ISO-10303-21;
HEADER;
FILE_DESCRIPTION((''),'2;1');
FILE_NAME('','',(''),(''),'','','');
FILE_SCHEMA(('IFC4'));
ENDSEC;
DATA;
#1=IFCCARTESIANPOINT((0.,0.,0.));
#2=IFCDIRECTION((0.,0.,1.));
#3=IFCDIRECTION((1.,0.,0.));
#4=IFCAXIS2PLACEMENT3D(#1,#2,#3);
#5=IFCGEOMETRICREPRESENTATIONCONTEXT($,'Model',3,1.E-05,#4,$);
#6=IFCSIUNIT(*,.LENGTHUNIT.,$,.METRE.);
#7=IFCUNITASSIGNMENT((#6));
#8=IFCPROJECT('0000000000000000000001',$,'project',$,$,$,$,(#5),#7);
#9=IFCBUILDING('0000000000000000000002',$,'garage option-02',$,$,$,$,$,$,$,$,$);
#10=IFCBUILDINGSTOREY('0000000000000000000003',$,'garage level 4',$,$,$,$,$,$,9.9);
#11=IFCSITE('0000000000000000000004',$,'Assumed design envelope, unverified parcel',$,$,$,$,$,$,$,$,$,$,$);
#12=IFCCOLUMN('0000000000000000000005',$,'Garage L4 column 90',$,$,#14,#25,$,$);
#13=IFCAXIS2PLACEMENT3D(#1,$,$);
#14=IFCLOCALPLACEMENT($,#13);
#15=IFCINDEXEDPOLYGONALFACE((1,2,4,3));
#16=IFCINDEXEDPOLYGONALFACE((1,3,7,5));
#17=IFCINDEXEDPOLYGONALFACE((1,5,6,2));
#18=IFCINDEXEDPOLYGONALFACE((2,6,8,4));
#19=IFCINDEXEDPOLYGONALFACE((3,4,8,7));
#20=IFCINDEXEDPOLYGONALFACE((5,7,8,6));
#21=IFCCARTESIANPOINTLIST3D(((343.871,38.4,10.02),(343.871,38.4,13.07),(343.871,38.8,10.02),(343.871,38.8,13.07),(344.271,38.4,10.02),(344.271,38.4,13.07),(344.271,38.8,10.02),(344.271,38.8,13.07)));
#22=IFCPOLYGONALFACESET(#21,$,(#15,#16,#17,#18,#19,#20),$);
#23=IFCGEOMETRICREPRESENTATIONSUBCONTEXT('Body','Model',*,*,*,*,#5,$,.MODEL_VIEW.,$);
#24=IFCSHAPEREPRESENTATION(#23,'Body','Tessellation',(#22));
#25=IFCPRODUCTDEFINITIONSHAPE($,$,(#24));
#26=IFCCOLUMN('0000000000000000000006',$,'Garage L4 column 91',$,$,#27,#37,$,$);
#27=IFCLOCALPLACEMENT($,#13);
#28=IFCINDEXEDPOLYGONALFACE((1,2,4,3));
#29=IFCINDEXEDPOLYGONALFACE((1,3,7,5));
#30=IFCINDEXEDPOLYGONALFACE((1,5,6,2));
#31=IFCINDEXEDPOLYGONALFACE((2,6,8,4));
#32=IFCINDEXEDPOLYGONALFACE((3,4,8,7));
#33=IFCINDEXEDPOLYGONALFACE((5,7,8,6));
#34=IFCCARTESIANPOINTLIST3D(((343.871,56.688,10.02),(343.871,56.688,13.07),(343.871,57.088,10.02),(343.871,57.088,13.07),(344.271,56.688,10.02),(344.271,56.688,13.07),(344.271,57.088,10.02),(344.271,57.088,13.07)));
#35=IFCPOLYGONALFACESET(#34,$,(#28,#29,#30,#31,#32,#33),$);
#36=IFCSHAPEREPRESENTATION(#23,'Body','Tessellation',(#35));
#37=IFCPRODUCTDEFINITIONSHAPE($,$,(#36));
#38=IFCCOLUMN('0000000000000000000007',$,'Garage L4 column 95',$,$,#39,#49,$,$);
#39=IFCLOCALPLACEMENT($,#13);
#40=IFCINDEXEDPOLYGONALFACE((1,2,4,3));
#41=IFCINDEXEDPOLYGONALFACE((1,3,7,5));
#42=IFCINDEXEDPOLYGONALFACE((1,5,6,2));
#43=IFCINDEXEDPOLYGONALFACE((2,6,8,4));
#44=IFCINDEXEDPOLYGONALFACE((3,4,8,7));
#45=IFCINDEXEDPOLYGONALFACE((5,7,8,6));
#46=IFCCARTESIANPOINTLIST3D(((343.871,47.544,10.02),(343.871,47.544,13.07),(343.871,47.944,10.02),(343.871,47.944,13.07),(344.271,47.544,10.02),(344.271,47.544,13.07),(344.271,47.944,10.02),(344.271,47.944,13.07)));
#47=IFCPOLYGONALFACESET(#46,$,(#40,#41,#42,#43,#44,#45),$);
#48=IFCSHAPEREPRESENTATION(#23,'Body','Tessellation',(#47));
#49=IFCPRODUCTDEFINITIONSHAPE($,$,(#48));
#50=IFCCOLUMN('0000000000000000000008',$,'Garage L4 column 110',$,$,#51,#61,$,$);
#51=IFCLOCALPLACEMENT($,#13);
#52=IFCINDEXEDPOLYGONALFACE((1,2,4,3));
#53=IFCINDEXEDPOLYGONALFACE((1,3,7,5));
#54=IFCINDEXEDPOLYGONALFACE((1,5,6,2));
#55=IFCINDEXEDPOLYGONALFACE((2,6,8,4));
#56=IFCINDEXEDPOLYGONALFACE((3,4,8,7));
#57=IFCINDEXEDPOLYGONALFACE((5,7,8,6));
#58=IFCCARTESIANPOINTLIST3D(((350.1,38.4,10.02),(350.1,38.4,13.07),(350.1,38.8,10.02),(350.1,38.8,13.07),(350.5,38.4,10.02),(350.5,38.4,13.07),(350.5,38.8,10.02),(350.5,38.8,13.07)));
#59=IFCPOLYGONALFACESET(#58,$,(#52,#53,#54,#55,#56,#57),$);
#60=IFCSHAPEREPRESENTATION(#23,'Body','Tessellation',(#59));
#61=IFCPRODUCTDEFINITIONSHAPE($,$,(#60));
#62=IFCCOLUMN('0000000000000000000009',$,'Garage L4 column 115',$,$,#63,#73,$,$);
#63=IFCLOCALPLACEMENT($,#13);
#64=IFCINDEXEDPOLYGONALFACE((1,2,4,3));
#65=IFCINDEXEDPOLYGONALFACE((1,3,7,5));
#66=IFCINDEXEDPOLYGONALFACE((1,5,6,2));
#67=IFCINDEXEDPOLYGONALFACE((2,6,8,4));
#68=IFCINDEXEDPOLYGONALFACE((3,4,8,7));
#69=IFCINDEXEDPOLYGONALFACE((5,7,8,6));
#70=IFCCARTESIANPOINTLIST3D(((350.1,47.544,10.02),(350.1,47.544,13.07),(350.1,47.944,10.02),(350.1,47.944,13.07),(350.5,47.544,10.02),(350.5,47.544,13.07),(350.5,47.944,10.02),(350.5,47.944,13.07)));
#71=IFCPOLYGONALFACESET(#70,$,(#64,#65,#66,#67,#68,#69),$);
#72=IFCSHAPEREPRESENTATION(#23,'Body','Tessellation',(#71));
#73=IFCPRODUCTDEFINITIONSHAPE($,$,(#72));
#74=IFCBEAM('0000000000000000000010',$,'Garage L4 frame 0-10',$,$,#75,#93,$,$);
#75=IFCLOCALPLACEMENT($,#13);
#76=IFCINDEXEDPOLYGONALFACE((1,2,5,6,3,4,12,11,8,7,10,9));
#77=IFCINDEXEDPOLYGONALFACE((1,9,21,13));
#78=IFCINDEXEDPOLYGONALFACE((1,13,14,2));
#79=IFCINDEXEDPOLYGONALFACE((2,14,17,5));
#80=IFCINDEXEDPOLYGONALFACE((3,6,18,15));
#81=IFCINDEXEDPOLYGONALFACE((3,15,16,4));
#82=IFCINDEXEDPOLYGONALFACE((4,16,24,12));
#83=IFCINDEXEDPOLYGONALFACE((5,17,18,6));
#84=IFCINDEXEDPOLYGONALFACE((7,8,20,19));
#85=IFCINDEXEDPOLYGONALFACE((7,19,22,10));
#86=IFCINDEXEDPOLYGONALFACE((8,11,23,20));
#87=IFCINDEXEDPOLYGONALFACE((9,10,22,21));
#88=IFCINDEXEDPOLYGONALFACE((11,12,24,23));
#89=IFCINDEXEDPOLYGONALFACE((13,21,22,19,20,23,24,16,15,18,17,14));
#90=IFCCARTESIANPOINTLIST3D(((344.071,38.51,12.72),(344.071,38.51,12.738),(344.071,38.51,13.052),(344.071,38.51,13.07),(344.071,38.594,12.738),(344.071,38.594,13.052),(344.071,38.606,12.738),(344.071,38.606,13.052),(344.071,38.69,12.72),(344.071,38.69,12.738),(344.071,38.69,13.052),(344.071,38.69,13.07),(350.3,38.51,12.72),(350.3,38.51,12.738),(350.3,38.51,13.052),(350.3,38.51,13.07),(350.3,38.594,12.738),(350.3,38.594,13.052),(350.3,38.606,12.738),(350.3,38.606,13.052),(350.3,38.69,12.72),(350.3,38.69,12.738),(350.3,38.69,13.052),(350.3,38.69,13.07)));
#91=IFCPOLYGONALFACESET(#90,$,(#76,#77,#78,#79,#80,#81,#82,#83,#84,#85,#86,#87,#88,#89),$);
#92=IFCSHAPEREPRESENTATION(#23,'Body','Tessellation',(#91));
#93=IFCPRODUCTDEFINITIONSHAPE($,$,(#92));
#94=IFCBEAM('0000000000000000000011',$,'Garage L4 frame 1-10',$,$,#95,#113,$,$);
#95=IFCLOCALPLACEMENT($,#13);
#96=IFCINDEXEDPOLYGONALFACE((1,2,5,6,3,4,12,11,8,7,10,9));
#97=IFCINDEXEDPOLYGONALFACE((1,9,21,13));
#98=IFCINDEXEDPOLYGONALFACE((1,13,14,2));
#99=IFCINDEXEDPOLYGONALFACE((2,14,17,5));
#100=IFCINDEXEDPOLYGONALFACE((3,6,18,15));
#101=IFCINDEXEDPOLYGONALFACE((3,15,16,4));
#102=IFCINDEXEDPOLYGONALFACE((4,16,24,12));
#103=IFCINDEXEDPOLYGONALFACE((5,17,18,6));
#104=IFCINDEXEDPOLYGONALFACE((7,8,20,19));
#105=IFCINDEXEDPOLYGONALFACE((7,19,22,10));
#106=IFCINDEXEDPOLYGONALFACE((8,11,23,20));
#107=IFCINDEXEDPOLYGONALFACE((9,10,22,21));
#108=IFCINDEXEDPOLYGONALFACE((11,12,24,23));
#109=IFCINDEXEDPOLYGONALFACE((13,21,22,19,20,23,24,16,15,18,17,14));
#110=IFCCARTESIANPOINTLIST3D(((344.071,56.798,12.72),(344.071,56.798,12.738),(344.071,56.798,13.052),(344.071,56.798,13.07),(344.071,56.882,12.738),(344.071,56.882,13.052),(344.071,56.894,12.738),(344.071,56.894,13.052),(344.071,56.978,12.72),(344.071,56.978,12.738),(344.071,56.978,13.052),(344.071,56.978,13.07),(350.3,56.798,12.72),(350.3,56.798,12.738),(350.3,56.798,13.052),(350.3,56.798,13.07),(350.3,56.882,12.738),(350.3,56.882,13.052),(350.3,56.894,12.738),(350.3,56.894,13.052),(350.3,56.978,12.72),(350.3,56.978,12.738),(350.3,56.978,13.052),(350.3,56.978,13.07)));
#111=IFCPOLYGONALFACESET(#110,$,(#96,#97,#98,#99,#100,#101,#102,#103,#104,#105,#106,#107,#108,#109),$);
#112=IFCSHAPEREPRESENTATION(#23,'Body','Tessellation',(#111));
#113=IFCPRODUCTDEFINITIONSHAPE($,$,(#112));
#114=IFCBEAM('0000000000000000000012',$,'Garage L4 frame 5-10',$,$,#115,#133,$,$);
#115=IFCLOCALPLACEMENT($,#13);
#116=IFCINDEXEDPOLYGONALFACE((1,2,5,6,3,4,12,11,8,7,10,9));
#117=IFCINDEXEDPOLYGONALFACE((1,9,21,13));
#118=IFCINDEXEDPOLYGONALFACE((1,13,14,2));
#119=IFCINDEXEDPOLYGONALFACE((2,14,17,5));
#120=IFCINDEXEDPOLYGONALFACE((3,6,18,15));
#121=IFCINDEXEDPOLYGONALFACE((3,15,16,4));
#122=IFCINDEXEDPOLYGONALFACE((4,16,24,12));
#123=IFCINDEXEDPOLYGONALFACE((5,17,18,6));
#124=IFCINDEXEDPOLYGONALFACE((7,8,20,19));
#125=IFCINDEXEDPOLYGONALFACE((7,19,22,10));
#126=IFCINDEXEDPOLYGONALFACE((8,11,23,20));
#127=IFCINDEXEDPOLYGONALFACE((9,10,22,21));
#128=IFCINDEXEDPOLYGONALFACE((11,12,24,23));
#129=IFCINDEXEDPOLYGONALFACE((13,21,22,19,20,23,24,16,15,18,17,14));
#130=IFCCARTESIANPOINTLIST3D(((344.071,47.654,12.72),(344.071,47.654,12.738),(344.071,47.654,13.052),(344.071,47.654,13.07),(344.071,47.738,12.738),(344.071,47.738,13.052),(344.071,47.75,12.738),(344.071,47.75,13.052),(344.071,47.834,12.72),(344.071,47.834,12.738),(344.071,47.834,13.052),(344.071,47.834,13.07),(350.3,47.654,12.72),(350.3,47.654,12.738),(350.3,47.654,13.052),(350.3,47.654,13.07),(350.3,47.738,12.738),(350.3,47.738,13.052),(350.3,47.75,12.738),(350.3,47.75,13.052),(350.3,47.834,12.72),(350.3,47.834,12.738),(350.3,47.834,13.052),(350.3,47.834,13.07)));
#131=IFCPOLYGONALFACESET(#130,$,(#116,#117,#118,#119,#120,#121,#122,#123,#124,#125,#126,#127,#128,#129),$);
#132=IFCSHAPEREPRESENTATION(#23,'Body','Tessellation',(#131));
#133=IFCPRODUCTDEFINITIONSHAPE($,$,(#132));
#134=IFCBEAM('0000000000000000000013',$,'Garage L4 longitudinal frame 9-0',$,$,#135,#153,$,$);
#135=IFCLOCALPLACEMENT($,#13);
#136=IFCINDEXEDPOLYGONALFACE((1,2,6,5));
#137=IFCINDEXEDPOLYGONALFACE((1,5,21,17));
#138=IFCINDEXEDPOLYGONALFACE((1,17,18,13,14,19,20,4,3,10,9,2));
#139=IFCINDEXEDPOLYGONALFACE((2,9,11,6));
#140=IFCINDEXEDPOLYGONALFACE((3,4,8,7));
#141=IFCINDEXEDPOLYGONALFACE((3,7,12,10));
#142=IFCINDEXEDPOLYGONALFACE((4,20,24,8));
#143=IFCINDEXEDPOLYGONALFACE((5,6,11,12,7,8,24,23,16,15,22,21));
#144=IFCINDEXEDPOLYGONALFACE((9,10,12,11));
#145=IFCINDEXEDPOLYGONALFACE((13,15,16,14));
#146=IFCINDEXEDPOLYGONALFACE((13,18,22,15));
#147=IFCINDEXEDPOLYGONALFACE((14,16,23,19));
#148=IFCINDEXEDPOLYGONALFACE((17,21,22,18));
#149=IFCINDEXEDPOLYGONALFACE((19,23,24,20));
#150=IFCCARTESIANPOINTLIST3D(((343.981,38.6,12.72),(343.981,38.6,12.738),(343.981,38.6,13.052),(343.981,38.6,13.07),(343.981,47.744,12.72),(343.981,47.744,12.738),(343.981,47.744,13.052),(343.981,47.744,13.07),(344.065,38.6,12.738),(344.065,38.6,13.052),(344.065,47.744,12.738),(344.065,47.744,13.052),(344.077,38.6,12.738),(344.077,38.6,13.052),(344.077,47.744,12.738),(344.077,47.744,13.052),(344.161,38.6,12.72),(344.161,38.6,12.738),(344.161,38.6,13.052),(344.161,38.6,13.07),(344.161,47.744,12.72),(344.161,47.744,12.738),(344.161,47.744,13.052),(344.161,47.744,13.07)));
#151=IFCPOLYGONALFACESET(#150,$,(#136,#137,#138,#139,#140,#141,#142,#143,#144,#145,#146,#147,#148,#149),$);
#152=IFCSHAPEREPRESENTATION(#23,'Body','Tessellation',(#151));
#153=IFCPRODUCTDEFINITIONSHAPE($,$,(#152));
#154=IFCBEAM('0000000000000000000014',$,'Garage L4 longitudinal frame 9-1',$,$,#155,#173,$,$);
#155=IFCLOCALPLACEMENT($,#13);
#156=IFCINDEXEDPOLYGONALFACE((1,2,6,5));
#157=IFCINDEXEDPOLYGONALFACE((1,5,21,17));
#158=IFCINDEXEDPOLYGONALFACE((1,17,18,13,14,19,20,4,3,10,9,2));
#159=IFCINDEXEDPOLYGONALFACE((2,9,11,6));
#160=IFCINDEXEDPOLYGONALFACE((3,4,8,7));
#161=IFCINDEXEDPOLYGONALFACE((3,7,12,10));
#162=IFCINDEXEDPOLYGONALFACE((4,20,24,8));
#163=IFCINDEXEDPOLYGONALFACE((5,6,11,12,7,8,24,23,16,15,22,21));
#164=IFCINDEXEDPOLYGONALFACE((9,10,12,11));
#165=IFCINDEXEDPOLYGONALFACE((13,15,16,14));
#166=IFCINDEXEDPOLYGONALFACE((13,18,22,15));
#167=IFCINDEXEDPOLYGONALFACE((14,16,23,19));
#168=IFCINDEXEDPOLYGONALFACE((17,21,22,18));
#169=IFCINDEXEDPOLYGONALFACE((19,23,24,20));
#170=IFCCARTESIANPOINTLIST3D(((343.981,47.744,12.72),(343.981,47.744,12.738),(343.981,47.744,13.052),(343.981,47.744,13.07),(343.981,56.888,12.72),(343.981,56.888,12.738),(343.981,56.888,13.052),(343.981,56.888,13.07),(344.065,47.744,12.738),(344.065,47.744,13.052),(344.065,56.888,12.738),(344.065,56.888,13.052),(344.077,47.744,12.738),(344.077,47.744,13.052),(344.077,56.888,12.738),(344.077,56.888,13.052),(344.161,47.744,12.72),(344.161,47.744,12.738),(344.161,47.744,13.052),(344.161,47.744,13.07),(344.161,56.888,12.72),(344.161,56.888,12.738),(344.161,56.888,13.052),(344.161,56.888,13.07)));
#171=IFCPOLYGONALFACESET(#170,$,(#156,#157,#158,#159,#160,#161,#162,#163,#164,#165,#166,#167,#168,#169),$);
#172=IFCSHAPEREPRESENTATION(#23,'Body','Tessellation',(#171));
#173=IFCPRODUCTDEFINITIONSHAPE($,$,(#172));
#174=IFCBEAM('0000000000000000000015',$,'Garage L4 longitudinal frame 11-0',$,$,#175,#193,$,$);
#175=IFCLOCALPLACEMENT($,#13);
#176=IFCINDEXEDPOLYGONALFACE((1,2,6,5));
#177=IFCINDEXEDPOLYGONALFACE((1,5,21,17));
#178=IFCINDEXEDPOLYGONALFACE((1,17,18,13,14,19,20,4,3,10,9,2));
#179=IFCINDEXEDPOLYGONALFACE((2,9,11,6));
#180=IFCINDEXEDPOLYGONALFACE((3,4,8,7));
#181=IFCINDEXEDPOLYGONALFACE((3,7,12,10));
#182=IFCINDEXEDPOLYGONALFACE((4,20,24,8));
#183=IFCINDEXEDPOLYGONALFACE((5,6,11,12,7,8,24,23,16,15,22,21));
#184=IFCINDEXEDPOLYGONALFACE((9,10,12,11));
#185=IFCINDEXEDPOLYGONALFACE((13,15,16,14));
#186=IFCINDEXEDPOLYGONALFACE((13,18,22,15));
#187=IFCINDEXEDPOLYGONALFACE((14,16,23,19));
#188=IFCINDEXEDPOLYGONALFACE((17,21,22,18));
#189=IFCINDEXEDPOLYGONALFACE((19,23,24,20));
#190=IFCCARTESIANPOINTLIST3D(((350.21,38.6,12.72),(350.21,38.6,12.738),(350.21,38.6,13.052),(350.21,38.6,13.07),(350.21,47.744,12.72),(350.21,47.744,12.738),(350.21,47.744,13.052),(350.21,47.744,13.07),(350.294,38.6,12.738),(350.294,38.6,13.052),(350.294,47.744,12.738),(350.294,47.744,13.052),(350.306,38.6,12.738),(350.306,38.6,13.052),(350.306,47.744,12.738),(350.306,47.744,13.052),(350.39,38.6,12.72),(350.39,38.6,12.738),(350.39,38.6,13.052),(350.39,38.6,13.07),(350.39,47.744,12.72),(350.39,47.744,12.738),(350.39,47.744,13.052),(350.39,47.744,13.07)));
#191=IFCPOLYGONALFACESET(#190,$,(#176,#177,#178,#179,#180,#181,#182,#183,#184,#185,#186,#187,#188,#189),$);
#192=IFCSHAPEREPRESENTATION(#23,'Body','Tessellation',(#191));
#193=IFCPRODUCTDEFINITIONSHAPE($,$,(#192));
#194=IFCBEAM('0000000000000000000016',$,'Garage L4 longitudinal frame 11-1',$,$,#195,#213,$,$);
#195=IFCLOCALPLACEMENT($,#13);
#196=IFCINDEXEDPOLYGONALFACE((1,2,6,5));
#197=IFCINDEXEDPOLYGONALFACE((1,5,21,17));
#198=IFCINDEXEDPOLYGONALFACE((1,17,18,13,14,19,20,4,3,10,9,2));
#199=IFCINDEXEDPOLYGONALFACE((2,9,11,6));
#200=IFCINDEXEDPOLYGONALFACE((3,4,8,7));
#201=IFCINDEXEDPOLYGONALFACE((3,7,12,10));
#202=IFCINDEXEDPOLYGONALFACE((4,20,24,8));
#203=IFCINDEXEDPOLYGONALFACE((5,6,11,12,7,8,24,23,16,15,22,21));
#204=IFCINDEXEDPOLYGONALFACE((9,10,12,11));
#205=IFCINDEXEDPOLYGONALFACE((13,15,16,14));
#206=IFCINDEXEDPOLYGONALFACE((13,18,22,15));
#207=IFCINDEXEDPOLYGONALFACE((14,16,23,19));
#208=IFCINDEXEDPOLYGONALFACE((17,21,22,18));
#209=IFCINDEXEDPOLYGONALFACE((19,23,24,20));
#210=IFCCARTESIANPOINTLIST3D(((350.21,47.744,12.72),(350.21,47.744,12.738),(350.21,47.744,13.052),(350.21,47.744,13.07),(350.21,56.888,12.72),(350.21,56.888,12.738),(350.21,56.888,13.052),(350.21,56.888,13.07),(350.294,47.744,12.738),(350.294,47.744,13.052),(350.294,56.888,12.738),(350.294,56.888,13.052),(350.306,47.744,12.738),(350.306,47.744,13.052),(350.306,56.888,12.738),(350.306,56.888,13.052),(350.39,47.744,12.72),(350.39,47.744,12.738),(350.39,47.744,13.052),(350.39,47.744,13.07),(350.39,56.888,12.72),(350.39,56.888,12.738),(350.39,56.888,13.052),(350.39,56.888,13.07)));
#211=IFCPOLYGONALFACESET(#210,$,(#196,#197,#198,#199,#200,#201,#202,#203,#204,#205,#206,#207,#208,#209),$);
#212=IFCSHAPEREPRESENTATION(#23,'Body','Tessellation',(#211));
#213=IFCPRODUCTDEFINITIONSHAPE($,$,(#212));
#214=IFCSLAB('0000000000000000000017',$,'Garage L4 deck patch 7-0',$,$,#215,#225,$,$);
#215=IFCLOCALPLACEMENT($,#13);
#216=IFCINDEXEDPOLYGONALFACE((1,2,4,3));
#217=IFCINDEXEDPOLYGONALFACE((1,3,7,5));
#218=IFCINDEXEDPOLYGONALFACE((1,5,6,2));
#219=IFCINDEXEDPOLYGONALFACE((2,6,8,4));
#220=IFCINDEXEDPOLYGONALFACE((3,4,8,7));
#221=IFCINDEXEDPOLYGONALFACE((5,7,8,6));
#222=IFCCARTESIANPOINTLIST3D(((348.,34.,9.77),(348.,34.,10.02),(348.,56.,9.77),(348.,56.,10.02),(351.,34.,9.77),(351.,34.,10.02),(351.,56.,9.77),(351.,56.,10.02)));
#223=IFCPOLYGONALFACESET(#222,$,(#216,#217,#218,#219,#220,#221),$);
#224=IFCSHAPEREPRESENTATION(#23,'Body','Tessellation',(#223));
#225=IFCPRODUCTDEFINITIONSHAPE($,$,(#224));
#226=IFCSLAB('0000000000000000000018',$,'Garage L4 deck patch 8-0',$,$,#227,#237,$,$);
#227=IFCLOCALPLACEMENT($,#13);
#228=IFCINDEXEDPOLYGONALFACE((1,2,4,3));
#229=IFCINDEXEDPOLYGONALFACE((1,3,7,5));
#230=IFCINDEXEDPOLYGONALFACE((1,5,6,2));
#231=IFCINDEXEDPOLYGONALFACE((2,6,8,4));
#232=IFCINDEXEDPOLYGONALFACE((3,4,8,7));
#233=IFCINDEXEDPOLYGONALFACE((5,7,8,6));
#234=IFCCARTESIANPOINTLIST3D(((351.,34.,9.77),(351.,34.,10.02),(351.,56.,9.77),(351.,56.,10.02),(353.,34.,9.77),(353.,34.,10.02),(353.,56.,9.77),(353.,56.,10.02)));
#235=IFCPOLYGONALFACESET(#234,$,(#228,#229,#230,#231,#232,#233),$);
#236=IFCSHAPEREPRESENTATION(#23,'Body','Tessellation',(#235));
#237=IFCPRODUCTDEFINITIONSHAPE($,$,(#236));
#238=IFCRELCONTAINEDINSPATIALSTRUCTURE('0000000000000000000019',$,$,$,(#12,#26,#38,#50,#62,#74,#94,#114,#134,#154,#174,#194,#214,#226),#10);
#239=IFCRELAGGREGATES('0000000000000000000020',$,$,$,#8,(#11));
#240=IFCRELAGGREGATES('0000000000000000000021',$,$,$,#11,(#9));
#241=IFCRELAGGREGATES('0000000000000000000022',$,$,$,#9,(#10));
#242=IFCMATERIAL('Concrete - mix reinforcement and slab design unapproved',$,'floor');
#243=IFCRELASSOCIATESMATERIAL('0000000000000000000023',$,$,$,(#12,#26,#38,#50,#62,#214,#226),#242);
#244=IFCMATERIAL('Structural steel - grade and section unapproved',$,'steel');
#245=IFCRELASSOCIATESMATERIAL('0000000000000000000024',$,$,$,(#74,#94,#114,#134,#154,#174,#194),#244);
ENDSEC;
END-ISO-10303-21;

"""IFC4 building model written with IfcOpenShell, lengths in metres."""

from ifc_helpers import new_model, si_unit, frame, origin_with_axes, place, context, subcontext, project, spatial, rectangle, i_section, extrude, material, element, save


model = new_model("IFC4")

# Units and contexts
model_context = context("Model", 3, precision=1e-05, world=origin_with_axes())
body_context = subcontext(model_context, "Body", "Model", "MODEL_VIEW")
ifc_project = project(units=[si_unit("LENGTHUNIT", "METRE")], contexts=[model_context])

# Site, building, storey
site = spatial("IfcSite", under=ifc_project, Name="Assumed design envelope, unverified parcel")
building = spatial("IfcBuilding", under=site, Name="garage option-02")
storey = spatial("IfcBuildingStorey", under=building, Name="garage level 4", Elevation=9.9)

# Columns
ifc_material_1 = material(Name="Concrete - mix reinforcement and slab design unapproved", Category="floor")
for number, where, z_axis, x_axis, name in (
    (1, (344.071, 38.6, 10.02), (0.0, 0.0, 1.0), (1.0, 0.0, 0.0), "Garage L4 column 90"),
    (2, (344.071, 56.888, 10.02), (0.0, 0.0, 1.0), (1.0, 0.0, 0.0), "Garage L4 column 91"),
    (3, (344.071, 47.744, 10.02), (0.0, 0.0, 1.0), (1.0, 0.0, 0.0), "Garage L4 column 95"),
    (4, (350.3, 38.6, 10.02), (0.0, 0.0, 1.0), (1.0, 0.0, 0.0), "Garage L4 column 110"),
    (5, (350.3, 47.744, 10.02), (0.0, 0.0, 1.0), (1.0, 0.0, 0.0), "Garage L4 column 115"),
):
    element("IfcColumn", number, at=place(None, frame(where, z_axis=z_axis, x_axis=x_axis)), inside=storey, material=ifc_material_1, Name=name, context=body_context, shape_type="SweptSolid", body=[
        extrude(rectangle(XDim=0.4, YDim=0.4), origin_with_axes(), (0.0, 0.0, 1.0), 3.05),
    ])

# Beams
ifc_material_2 = material(Name="Structural steel - grade and section unapproved", Category="steel")
for number, where, z_axis, x_axis, name in (
    (6, (344.071, 38.6, 12.895), (1.0, 0.0, 0.0), (0.0, 1.0, 0.0), "Garage L4 frame 0-10"),
    (7, (344.071, 56.888, 12.895), (1.0, 0.0, 0.0), (0.0, 1.0, 0.0), "Garage L4 frame 1-10"),
    (8, (344.071, 47.744, 12.895), (1.0, 0.0, 0.0), (0.0, 1.0, 0.0), "Garage L4 frame 5-10"),
):
    element("IfcBeam", number, at=place(None, frame(where, z_axis=z_axis, x_axis=x_axis)), inside=storey, material=ifc_material_2, Name=name, context=body_context, shape_type="SweptSolid", body=[
        extrude(i_section(OverallWidth=0.18, OverallDepth=0.35, WebThickness=0.012, FlangeThickness=0.018, FilletRadius=0.0), origin_with_axes(), (0.0, 0.0, 1.0), 6.229),
    ])
for number, where, z_axis, x_axis, name in (
    (9, (344.071, 38.6, 12.895), (0.0, 1.0, 0.0), (-1.0, 0.0, 0.0), "Garage L4 longitudinal frame 9-0"),
    (10, (344.071, 47.744, 12.895), (0.0, 1.0, 0.0), (-1.0, 0.0, 0.0), "Garage L4 longitudinal frame 9-1"),
    (11, (350.3, 38.6, 12.895), (0.0, 1.0, 0.0), (-1.0, 0.0, 0.0), "Garage L4 longitudinal frame 11-0"),
    (12, (350.3, 47.744, 12.895), (0.0, 1.0, 0.0), (-1.0, 0.0, 0.0), "Garage L4 longitudinal frame 11-1"),
):
    element("IfcBeam", number, at=place(None, frame(where, z_axis=z_axis, x_axis=x_axis)), inside=storey, material=ifc_material_2, Name=name, context=body_context, shape_type="SweptSolid", body=[
        extrude(i_section(OverallWidth=0.18, OverallDepth=0.35, WebThickness=0.012, FlangeThickness=0.018, FilletRadius=0.0), origin_with_axes(), (0.0, 0.0, 1.0), 9.144),
    ])

# Slabs
slab_1_placement = place(None, frame((349.5, 45.0, 9.77), z_axis=(0.0, 0.0, 1.0), x_axis=(1.0, 0.0, 0.0)))
element("IfcSlab", 13, at=slab_1_placement, inside=storey, material=ifc_material_1, Name="Garage L4 deck patch 7-0", context=body_context, shape_type="SweptSolid", body=[
    extrude(rectangle(XDim=3.0, YDim=22.0), origin_with_axes(), (0.0, 0.0, 1.0), 0.25),
])
slab_2_placement = place(None, frame((352.0, 45.0, 9.77), z_axis=(0.0, 0.0, 1.0), x_axis=(1.0, 0.0, 0.0)))
element("IfcSlab", 14, at=slab_2_placement, inside=storey, material=ifc_material_1, Name="Garage L4 deck patch 8-0", context=body_context, shape_type="SweptSolid", body=[
    extrude(rectangle(XDim=2.0, YDim=22.0), origin_with_axes(), (0.0, 0.0, 1.0), 0.25),
])

save(model, "model.ifc")
